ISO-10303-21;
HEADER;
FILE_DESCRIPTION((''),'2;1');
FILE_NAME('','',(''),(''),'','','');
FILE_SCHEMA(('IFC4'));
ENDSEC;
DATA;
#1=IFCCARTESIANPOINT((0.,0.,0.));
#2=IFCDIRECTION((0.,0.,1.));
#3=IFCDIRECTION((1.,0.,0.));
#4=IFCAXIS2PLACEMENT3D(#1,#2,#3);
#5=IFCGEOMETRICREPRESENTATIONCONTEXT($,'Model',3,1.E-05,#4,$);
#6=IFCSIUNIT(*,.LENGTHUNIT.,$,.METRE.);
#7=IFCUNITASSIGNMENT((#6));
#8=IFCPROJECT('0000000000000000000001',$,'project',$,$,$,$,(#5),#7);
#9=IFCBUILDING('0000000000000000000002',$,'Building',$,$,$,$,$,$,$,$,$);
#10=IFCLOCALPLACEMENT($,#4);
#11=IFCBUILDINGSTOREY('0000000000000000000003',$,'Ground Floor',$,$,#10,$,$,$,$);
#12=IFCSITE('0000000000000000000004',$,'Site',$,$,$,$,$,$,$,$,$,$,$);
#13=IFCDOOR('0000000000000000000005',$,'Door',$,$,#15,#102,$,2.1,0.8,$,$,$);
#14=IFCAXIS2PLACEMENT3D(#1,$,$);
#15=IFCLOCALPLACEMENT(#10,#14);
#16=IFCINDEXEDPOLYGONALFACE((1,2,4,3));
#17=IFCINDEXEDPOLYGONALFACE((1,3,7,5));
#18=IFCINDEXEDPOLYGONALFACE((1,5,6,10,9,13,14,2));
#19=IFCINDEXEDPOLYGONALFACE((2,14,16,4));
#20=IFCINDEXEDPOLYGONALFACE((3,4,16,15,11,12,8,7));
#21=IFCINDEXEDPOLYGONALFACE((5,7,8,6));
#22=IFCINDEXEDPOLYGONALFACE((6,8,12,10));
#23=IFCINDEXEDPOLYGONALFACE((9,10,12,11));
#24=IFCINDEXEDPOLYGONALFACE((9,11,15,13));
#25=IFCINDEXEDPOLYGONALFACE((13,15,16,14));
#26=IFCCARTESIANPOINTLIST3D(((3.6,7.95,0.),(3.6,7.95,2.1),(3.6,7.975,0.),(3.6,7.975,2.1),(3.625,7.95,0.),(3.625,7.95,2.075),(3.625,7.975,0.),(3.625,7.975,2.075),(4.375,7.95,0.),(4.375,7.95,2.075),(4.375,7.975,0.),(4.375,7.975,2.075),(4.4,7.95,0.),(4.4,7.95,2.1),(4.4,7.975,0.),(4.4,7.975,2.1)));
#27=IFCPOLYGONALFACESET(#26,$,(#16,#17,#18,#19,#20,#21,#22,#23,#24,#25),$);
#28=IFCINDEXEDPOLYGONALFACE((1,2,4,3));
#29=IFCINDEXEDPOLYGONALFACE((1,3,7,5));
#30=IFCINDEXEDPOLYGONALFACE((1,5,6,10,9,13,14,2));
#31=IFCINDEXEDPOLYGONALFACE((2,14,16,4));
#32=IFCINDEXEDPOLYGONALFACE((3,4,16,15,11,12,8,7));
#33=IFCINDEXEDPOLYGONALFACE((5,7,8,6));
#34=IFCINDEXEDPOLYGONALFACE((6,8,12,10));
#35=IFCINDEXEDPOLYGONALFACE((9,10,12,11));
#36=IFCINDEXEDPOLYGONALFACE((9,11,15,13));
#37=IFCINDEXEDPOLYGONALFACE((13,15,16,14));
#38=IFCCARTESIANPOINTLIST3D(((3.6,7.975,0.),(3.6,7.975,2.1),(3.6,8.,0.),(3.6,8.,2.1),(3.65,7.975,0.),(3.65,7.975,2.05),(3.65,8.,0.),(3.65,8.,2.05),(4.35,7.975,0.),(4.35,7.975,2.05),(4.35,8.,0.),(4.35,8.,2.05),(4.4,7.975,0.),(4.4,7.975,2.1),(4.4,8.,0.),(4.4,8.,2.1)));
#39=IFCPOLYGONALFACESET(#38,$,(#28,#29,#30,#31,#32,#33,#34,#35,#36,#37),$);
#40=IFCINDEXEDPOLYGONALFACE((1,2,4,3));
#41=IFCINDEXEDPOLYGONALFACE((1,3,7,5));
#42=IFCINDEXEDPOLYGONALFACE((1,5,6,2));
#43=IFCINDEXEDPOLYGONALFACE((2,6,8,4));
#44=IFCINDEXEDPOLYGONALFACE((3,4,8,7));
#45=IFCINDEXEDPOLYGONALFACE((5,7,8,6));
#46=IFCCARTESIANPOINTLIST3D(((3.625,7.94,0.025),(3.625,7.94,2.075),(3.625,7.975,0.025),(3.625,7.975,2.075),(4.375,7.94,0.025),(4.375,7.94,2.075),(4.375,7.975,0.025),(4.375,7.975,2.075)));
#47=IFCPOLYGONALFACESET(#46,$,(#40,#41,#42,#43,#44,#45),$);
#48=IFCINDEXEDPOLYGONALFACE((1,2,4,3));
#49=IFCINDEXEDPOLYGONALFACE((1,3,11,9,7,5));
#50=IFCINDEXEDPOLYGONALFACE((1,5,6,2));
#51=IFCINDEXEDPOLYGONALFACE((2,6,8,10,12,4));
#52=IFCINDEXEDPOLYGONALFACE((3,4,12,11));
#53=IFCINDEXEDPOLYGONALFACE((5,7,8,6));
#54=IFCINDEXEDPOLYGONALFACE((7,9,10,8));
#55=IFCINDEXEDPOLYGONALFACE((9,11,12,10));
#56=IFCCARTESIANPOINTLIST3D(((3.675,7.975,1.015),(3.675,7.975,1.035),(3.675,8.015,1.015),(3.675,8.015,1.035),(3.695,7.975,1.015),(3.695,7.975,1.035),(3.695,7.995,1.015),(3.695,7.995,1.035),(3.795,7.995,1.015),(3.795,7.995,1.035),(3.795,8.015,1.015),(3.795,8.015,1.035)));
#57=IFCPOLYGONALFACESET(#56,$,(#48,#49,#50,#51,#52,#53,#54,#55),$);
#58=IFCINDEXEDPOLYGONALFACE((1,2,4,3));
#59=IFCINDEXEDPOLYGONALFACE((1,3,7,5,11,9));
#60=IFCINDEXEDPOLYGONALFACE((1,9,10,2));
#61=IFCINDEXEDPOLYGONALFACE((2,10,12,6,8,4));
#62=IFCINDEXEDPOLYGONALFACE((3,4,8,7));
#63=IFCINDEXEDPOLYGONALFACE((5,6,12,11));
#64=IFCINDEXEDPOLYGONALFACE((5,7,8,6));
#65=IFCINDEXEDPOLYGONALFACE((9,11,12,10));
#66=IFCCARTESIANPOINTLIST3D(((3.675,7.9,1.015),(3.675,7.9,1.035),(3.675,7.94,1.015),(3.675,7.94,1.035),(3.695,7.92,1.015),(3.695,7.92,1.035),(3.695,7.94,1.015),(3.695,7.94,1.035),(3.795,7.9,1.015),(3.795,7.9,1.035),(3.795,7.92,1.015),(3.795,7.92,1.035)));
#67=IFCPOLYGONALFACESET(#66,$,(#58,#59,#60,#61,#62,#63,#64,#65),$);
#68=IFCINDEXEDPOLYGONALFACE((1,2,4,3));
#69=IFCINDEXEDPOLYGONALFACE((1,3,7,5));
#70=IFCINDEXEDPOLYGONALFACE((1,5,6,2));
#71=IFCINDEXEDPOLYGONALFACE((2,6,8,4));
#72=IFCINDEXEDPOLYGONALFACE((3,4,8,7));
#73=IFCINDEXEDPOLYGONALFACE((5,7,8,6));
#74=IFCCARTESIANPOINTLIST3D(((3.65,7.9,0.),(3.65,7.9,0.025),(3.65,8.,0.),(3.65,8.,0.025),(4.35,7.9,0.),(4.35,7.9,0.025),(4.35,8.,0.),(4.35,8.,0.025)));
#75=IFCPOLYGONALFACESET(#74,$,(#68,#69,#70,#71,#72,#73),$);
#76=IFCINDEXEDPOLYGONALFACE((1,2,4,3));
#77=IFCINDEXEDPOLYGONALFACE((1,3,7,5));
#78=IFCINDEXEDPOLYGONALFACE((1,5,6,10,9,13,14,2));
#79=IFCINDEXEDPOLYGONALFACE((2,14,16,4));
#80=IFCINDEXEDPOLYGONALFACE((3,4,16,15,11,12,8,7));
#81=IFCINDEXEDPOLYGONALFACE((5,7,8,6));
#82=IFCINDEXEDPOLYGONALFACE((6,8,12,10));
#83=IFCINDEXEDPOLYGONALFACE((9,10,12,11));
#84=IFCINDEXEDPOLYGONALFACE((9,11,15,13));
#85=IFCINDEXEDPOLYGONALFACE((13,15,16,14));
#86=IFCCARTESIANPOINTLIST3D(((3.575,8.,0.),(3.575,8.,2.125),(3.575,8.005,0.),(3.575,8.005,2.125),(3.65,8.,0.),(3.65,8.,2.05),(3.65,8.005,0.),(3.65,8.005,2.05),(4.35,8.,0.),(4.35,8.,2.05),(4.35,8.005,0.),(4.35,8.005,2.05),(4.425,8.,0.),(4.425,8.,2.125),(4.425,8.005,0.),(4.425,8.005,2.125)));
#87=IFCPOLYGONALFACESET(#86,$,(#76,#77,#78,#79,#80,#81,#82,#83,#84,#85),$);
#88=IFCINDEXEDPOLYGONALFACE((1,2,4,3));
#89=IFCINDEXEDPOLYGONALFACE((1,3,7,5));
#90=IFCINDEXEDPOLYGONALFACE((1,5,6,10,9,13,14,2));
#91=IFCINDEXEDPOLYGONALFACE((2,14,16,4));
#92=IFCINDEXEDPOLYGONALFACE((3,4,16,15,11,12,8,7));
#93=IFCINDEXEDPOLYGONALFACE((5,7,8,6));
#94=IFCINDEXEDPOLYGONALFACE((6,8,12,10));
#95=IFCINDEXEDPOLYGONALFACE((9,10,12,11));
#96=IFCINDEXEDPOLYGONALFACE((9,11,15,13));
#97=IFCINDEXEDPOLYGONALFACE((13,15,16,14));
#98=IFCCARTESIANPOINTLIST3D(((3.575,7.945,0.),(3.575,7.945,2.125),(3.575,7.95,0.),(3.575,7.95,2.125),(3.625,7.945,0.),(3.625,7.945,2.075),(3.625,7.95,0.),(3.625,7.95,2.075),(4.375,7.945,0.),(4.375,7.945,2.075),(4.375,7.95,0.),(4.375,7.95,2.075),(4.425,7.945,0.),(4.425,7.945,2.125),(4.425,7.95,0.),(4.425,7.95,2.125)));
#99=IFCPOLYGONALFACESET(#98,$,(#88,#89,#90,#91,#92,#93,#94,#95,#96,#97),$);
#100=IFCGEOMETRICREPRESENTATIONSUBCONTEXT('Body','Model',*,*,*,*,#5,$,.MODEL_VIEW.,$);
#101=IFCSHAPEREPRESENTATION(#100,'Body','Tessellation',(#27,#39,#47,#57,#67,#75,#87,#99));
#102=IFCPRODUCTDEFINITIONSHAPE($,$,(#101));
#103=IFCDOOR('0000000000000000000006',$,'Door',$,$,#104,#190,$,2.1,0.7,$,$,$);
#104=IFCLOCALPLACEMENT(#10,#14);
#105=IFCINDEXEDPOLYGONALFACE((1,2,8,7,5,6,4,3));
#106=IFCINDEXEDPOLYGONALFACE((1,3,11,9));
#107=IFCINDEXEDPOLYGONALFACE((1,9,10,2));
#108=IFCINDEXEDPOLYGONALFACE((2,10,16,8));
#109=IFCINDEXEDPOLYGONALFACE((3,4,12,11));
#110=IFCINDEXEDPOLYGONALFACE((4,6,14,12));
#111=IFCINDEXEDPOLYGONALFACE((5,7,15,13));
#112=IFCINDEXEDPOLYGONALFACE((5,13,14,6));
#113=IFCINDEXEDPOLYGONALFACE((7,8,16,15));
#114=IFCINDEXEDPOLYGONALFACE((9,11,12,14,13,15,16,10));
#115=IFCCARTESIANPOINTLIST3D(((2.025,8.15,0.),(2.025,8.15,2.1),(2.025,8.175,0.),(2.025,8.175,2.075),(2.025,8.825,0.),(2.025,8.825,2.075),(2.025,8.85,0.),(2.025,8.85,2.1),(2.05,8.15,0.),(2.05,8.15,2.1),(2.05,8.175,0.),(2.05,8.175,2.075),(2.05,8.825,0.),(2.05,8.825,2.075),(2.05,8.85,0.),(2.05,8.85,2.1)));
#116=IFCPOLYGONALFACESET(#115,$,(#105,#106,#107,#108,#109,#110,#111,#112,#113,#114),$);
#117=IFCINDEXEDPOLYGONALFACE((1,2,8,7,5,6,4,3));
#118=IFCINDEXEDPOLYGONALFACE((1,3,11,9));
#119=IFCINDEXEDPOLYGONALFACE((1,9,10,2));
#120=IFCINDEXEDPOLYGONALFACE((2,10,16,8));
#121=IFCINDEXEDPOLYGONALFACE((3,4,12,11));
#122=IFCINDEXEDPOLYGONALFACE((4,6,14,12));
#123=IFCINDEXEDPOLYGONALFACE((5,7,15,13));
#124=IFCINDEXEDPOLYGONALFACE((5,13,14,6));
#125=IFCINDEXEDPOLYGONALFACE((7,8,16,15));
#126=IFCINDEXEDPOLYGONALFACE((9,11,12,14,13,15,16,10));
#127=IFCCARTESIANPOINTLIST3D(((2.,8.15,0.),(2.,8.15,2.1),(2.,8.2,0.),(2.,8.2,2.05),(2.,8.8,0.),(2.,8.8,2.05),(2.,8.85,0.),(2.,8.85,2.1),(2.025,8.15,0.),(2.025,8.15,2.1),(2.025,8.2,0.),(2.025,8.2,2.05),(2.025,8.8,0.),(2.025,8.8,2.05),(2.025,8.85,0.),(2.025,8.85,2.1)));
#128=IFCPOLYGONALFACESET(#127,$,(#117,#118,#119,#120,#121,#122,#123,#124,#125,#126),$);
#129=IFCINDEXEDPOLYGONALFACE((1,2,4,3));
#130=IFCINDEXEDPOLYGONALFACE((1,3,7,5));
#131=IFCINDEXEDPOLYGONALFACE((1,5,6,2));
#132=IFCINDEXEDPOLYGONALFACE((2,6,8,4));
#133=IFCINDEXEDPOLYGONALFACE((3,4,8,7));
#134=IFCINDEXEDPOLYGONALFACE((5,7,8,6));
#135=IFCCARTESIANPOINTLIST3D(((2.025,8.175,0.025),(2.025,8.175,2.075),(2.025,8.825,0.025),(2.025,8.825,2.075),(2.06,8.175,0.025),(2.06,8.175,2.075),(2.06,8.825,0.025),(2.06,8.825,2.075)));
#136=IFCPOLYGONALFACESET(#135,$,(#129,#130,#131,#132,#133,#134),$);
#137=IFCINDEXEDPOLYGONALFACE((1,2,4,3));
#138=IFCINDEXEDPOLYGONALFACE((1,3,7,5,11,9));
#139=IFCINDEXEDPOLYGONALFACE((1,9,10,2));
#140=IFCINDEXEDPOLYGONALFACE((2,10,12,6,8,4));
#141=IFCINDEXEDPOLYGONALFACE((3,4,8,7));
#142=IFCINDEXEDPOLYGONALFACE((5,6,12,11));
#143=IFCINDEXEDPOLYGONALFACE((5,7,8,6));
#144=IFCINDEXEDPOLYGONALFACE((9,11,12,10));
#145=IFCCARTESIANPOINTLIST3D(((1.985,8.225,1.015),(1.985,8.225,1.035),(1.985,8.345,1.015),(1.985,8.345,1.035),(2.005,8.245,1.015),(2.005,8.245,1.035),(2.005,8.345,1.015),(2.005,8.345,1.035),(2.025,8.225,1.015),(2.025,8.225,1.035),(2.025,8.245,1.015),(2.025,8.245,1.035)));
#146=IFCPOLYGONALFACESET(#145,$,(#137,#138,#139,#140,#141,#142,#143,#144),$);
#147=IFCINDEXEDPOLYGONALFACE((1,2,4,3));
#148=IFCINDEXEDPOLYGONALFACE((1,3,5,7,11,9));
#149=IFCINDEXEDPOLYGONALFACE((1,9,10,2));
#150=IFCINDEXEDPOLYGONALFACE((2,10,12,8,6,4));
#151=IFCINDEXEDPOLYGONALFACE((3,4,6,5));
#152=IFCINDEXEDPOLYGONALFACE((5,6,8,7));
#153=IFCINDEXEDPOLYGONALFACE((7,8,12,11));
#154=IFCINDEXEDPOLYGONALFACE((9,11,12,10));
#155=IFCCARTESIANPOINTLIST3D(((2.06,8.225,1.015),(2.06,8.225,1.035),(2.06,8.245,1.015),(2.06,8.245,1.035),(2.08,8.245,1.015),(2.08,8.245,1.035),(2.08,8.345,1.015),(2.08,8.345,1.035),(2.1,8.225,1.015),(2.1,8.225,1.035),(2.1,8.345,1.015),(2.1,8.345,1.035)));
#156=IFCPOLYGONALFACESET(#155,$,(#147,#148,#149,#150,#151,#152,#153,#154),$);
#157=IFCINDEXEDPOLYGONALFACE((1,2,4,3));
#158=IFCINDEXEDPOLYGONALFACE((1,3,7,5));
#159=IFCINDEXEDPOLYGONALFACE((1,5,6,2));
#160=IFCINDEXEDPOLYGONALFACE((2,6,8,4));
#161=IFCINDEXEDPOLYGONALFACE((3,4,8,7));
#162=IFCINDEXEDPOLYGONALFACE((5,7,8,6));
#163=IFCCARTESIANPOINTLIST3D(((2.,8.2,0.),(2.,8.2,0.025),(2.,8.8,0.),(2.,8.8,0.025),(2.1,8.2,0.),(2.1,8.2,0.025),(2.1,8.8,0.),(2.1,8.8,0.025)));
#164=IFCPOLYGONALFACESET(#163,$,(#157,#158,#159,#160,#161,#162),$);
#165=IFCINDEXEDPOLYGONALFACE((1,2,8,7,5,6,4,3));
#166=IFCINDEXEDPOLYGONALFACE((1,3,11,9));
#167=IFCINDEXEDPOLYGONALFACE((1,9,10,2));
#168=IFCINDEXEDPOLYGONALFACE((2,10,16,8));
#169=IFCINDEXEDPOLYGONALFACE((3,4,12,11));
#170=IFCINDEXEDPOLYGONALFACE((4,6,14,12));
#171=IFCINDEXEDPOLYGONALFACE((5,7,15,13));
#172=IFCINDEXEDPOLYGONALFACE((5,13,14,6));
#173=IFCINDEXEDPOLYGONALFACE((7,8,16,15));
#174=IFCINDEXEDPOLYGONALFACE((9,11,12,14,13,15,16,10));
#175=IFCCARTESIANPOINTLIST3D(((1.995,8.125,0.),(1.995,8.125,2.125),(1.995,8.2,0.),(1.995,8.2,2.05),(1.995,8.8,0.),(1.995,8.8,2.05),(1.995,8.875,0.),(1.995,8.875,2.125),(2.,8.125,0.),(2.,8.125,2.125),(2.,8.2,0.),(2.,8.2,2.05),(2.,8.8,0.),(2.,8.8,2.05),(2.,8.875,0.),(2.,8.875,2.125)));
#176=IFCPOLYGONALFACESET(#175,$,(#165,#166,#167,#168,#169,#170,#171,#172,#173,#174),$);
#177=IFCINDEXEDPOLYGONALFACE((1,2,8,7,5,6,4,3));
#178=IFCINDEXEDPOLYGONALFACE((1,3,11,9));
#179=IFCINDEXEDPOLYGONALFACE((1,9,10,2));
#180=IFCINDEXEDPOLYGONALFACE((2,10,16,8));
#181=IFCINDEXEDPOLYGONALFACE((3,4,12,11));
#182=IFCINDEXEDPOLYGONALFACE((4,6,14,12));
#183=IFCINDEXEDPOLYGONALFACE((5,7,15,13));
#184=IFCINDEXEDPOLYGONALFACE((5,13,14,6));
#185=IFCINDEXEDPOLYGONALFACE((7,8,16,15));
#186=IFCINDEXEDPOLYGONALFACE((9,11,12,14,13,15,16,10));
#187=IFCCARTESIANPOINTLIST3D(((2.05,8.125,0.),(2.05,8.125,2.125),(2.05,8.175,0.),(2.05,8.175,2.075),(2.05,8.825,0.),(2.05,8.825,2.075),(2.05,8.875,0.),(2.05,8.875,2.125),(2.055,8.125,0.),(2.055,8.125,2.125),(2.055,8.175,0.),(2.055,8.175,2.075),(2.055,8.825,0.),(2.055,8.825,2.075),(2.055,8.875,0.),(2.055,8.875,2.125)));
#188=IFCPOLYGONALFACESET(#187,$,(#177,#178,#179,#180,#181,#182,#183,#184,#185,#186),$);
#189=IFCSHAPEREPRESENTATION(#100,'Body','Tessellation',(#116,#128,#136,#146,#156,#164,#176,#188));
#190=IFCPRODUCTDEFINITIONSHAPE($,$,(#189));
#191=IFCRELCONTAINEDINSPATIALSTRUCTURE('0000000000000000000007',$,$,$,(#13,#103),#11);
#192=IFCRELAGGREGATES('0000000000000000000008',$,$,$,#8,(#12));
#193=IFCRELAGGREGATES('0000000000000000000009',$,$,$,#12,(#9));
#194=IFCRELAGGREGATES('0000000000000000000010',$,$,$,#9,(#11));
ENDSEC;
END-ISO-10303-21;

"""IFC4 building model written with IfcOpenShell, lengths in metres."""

from ifc_helpers import new_model, si_unit, frame, origin_with_axes, place, context, subcontext, project, spatial, line, indexed_curve, outline, extrude, element, save


model = new_model("IFC4")

# Units and contexts
model_context = context("Model", 3, precision=1e-05, world=origin_with_axes())
body_context = subcontext(model_context, "Body", "Model", "MODEL_VIEW")
ifc_project = project(units=[si_unit("LENGTHUNIT", "METRE")], contexts=[model_context])

# Site, building, storey
site = spatial("IfcSite", under=ifc_project, Name="Site")
building = spatial("IfcBuilding", under=site, Name="Building")
storey_placement = place(None, origin_with_axes())
storey = spatial("IfcBuildingStorey", under=building, at=storey_placement, Name="Ground Floor")

# Doors
door_1_placement = place(storey_placement, frame((4.4, 8.0, 0.0), z_axis=(0.0, 0.0, 1.0), x_axis=(-1.0, 0.0, 0.0)))
element("IfcDoor", 1, at=door_1_placement, inside=storey, Name="Door", OverallHeight=2.1, OverallWidth=0.8, context=body_context, shape_type="SweptSolid", body=[
    extrude(outline(indexed_curve([(0.0, 0.0), (0.0, 2.1), (0.8, 2.1), (0.8, 0.0), (0.775, 0.0), (0.775, 2.075), (0.025, 2.075), (0.025, 0.0)], segments=[line(1, 2, 3, 4, 5, 6, 7, 8, 1)])), frame((0.0, 0.025, 0.0), z_axis=(0.0, -1.0, 0.0), x_axis=(1.0, 0.0, 0.0)), (0.0, 0.0, -1.0), 0.025),
    extrude(outline(indexed_curve([(0.0, 0.0), (0.0, 2.1), (0.8, 2.1), (0.8, 0.0), (0.75, 0.0), (0.75, 2.05), (0.05, 2.05), (0.05, 0.0)], segments=[line(1, 2, 3, 4, 5, 6, 7, 8, 1)])), frame((0.0, 0.0, 0.0), z_axis=(0.0, -1.0, 0.0), x_axis=(1.0, 0.0, 0.0)), (0.0, 0.0, -1.0), 0.025),
    extrude(outline(indexed_curve([(0.0, 0.0), (0.75, 0.0), (0.75, 0.035), (0.0, 0.035)], segments=[line(1, 2, 3, 4, 1)])), frame((0.025, 0.025, 0.025), z_axis=(0.0, 0.0, 1.0), x_axis=(1.0, 0.0, 0.0)), (0.0, 0.0, 1.0), 2.05),
    extrude(outline(indexed_curve([(0.0, 0.0), (0.0, -0.04), (-0.12, -0.04), (-0.12, -0.02), (-0.02, -0.02), (-0.02, 0.0)], segments=[line(1, 2, 3, 4, 5, 6, 1)])), frame((0.725, 0.025, 1.015), z_axis=(0.0, 0.0, 1.0), x_axis=(1.0, 0.0, 0.0)), (0.0, 0.0, 1.0), 0.02),
    extrude(outline(indexed_curve([(0.0, 0.0), (0.0, 0.04), (-0.12, 0.04), (-0.12, 0.02), (-0.02, 0.02), (-0.02, 0.0)], segments=[line(1, 2, 3, 4, 5, 6, 1)])), frame((0.725, 0.06, 1.015), z_axis=(0.0, 0.0, 1.0), x_axis=(1.0, 0.0, 0.0)), (0.0, 0.0, 1.0), 0.02),
    extrude(outline(indexed_curve([(0.0, 0.0), (0.7, 0.0), (0.7, 0.1), (0.0, 0.1)], segments=[line(1, 2, 3, 4, 1)])), frame((0.05, 0.0, 0.0), z_axis=(0.0, 0.0, 1.0), x_axis=(1.0, 0.0, 0.0)), (0.0, 0.0, 1.0), 0.025),
    extrude(outline(indexed_curve([(0.0, 0.0), (0.0, 2.125), (0.85, 2.125), (0.85, 0.0), (0.775, 0.0), (0.775, 2.05), (0.075, 2.05), (0.075, 0.0)], segments=[line(1, 2, 3, 4, 5, 6, 7, 8, 1)])), frame((-0.025, -0.005, 0.0), z_axis=(0.0, -1.0, 0.0), x_axis=(1.0, 0.0, 0.0)), (0.0, 0.0, -1.0), 0.005),
    extrude(outline(indexed_curve([(0.0, 0.0), (0.0, 2.125), (0.85, 2.125), (0.85, 0.0), (0.8, 0.0), (0.8, 2.075), (0.05, 2.075), (0.05, 0.0)], segments=[line(1, 2, 3, 4, 5, 6, 7, 8, 1)])), frame((-0.025, 0.05, 0.0), z_axis=(0.0, -1.0, 0.0), x_axis=(1.0, 0.0, 0.0)), (0.0, 0.0, -1.0), 0.005),
])
door_2_placement = place(storey_placement, frame((2.0, 8.85, 0.0), z_axis=(0.0, 0.0, 1.0), x_axis=(0.0, -1.0, 0.0)))
element("IfcDoor", 2, at=door_2_placement, inside=storey, Name="Door", OverallHeight=2.1, OverallWidth=0.7, context=body_context, shape_type="SweptSolid", body=[
    extrude(outline(indexed_curve([(0.0, 0.0), (0.0, 2.1), (0.7, 2.1), (0.7, 0.0), (0.675, 0.0), (0.675, 2.075), (0.025, 2.075), (0.025, 0.0)], segments=[line(1, 2, 3, 4, 5, 6, 7, 8, 1)])), frame((0.0, 0.025, 0.0), z_axis=(0.0, -1.0, 0.0), x_axis=(1.0, 0.0, 0.0)), (0.0, 0.0, -1.0), 0.025),
    extrude(outline(indexed_curve([(0.0, 0.0), (0.0, 2.1), (0.7, 2.1), (0.7, 0.0), (0.65, 0.0), (0.65, 2.05), (0.05, 2.05), (0.05, 0.0)], segments=[line(1, 2, 3, 4, 5, 6, 7, 8, 1)])), frame((0.0, 0.0, 0.0), z_axis=(0.0, -1.0, 0.0), x_axis=(1.0, 0.0, 0.0)), (0.0, 0.0, -1.0), 0.025),
    extrude(outline(indexed_curve([(0.0, 0.0), (0.65, 0.0), (0.65, 0.035), (0.0, 0.035)], segments=[line(1, 2, 3, 4, 1)])), frame((0.025, 0.025, 0.025), z_axis=(0.0, 0.0, 1.0), x_axis=(1.0, 0.0, 0.0)), (0.0, 0.0, 1.0), 2.05),
    extrude(outline(indexed_curve([(0.0, 0.0), (0.0, -0.04), (-0.12, -0.04), (-0.12, -0.02), (-0.02, -0.02), (-0.02, 0.0)], segments=[line(1, 2, 3, 4, 5, 6, 1)])), frame((0.625, 0.025, 1.015), z_axis=(0.0, 0.0, 1.0), x_axis=(1.0, 0.0, 0.0)), (0.0, 0.0, 1.0), 0.02),
    extrude(outline(indexed_curve([(0.0, 0.0), (0.0, 0.04), (-0.12, 0.04), (-0.12, 0.02), (-0.02, 0.02), (-0.02, 0.0)], segments=[line(1, 2, 3, 4, 5, 6, 1)])), frame((0.625, 0.06, 1.015), z_axis=(0.0, 0.0, 1.0), x_axis=(1.0, 0.0, 0.0)), (0.0, 0.0, 1.0), 0.02),
    extrude(outline(indexed_curve([(0.0, 0.0), (0.6, 0.0), (0.6, 0.1), (0.0, 0.1)], segments=[line(1, 2, 3, 4, 1)])), frame((0.05, 0.0, 0.0), z_axis=(0.0, 0.0, 1.0), x_axis=(1.0, 0.0, 0.0)), (0.0, 0.0, 1.0), 0.025),
    extrude(outline(indexed_curve([(0.0, 0.0), (0.0, 2.125), (0.75, 2.125), (0.75, 0.0), (0.675, 0.0), (0.675, 2.05), (0.075, 2.05), (0.075, 0.0)], segments=[line(1, 2, 3, 4, 5, 6, 7, 8, 1)])), frame((-0.025, -0.005, 0.0), z_axis=(0.0, -1.0, 0.0), x_axis=(1.0, 0.0, 0.0)), (0.0, 0.0, -1.0), 0.005),
    extrude(outline(indexed_curve([(0.0, 0.0), (0.0, 2.125), (0.75, 2.125), (0.75, 0.0), (0.7, 0.0), (0.7, 2.075), (0.05, 2.075), (0.05, 0.0)], segments=[line(1, 2, 3, 4, 5, 6, 7, 8, 1)])), frame((-0.025, 0.05, 0.0), z_axis=(0.0, -1.0, 0.0), x_axis=(1.0, 0.0, 0.0)), (0.0, 0.0, -1.0), 0.005),
])

save(model, "model.ifc")
